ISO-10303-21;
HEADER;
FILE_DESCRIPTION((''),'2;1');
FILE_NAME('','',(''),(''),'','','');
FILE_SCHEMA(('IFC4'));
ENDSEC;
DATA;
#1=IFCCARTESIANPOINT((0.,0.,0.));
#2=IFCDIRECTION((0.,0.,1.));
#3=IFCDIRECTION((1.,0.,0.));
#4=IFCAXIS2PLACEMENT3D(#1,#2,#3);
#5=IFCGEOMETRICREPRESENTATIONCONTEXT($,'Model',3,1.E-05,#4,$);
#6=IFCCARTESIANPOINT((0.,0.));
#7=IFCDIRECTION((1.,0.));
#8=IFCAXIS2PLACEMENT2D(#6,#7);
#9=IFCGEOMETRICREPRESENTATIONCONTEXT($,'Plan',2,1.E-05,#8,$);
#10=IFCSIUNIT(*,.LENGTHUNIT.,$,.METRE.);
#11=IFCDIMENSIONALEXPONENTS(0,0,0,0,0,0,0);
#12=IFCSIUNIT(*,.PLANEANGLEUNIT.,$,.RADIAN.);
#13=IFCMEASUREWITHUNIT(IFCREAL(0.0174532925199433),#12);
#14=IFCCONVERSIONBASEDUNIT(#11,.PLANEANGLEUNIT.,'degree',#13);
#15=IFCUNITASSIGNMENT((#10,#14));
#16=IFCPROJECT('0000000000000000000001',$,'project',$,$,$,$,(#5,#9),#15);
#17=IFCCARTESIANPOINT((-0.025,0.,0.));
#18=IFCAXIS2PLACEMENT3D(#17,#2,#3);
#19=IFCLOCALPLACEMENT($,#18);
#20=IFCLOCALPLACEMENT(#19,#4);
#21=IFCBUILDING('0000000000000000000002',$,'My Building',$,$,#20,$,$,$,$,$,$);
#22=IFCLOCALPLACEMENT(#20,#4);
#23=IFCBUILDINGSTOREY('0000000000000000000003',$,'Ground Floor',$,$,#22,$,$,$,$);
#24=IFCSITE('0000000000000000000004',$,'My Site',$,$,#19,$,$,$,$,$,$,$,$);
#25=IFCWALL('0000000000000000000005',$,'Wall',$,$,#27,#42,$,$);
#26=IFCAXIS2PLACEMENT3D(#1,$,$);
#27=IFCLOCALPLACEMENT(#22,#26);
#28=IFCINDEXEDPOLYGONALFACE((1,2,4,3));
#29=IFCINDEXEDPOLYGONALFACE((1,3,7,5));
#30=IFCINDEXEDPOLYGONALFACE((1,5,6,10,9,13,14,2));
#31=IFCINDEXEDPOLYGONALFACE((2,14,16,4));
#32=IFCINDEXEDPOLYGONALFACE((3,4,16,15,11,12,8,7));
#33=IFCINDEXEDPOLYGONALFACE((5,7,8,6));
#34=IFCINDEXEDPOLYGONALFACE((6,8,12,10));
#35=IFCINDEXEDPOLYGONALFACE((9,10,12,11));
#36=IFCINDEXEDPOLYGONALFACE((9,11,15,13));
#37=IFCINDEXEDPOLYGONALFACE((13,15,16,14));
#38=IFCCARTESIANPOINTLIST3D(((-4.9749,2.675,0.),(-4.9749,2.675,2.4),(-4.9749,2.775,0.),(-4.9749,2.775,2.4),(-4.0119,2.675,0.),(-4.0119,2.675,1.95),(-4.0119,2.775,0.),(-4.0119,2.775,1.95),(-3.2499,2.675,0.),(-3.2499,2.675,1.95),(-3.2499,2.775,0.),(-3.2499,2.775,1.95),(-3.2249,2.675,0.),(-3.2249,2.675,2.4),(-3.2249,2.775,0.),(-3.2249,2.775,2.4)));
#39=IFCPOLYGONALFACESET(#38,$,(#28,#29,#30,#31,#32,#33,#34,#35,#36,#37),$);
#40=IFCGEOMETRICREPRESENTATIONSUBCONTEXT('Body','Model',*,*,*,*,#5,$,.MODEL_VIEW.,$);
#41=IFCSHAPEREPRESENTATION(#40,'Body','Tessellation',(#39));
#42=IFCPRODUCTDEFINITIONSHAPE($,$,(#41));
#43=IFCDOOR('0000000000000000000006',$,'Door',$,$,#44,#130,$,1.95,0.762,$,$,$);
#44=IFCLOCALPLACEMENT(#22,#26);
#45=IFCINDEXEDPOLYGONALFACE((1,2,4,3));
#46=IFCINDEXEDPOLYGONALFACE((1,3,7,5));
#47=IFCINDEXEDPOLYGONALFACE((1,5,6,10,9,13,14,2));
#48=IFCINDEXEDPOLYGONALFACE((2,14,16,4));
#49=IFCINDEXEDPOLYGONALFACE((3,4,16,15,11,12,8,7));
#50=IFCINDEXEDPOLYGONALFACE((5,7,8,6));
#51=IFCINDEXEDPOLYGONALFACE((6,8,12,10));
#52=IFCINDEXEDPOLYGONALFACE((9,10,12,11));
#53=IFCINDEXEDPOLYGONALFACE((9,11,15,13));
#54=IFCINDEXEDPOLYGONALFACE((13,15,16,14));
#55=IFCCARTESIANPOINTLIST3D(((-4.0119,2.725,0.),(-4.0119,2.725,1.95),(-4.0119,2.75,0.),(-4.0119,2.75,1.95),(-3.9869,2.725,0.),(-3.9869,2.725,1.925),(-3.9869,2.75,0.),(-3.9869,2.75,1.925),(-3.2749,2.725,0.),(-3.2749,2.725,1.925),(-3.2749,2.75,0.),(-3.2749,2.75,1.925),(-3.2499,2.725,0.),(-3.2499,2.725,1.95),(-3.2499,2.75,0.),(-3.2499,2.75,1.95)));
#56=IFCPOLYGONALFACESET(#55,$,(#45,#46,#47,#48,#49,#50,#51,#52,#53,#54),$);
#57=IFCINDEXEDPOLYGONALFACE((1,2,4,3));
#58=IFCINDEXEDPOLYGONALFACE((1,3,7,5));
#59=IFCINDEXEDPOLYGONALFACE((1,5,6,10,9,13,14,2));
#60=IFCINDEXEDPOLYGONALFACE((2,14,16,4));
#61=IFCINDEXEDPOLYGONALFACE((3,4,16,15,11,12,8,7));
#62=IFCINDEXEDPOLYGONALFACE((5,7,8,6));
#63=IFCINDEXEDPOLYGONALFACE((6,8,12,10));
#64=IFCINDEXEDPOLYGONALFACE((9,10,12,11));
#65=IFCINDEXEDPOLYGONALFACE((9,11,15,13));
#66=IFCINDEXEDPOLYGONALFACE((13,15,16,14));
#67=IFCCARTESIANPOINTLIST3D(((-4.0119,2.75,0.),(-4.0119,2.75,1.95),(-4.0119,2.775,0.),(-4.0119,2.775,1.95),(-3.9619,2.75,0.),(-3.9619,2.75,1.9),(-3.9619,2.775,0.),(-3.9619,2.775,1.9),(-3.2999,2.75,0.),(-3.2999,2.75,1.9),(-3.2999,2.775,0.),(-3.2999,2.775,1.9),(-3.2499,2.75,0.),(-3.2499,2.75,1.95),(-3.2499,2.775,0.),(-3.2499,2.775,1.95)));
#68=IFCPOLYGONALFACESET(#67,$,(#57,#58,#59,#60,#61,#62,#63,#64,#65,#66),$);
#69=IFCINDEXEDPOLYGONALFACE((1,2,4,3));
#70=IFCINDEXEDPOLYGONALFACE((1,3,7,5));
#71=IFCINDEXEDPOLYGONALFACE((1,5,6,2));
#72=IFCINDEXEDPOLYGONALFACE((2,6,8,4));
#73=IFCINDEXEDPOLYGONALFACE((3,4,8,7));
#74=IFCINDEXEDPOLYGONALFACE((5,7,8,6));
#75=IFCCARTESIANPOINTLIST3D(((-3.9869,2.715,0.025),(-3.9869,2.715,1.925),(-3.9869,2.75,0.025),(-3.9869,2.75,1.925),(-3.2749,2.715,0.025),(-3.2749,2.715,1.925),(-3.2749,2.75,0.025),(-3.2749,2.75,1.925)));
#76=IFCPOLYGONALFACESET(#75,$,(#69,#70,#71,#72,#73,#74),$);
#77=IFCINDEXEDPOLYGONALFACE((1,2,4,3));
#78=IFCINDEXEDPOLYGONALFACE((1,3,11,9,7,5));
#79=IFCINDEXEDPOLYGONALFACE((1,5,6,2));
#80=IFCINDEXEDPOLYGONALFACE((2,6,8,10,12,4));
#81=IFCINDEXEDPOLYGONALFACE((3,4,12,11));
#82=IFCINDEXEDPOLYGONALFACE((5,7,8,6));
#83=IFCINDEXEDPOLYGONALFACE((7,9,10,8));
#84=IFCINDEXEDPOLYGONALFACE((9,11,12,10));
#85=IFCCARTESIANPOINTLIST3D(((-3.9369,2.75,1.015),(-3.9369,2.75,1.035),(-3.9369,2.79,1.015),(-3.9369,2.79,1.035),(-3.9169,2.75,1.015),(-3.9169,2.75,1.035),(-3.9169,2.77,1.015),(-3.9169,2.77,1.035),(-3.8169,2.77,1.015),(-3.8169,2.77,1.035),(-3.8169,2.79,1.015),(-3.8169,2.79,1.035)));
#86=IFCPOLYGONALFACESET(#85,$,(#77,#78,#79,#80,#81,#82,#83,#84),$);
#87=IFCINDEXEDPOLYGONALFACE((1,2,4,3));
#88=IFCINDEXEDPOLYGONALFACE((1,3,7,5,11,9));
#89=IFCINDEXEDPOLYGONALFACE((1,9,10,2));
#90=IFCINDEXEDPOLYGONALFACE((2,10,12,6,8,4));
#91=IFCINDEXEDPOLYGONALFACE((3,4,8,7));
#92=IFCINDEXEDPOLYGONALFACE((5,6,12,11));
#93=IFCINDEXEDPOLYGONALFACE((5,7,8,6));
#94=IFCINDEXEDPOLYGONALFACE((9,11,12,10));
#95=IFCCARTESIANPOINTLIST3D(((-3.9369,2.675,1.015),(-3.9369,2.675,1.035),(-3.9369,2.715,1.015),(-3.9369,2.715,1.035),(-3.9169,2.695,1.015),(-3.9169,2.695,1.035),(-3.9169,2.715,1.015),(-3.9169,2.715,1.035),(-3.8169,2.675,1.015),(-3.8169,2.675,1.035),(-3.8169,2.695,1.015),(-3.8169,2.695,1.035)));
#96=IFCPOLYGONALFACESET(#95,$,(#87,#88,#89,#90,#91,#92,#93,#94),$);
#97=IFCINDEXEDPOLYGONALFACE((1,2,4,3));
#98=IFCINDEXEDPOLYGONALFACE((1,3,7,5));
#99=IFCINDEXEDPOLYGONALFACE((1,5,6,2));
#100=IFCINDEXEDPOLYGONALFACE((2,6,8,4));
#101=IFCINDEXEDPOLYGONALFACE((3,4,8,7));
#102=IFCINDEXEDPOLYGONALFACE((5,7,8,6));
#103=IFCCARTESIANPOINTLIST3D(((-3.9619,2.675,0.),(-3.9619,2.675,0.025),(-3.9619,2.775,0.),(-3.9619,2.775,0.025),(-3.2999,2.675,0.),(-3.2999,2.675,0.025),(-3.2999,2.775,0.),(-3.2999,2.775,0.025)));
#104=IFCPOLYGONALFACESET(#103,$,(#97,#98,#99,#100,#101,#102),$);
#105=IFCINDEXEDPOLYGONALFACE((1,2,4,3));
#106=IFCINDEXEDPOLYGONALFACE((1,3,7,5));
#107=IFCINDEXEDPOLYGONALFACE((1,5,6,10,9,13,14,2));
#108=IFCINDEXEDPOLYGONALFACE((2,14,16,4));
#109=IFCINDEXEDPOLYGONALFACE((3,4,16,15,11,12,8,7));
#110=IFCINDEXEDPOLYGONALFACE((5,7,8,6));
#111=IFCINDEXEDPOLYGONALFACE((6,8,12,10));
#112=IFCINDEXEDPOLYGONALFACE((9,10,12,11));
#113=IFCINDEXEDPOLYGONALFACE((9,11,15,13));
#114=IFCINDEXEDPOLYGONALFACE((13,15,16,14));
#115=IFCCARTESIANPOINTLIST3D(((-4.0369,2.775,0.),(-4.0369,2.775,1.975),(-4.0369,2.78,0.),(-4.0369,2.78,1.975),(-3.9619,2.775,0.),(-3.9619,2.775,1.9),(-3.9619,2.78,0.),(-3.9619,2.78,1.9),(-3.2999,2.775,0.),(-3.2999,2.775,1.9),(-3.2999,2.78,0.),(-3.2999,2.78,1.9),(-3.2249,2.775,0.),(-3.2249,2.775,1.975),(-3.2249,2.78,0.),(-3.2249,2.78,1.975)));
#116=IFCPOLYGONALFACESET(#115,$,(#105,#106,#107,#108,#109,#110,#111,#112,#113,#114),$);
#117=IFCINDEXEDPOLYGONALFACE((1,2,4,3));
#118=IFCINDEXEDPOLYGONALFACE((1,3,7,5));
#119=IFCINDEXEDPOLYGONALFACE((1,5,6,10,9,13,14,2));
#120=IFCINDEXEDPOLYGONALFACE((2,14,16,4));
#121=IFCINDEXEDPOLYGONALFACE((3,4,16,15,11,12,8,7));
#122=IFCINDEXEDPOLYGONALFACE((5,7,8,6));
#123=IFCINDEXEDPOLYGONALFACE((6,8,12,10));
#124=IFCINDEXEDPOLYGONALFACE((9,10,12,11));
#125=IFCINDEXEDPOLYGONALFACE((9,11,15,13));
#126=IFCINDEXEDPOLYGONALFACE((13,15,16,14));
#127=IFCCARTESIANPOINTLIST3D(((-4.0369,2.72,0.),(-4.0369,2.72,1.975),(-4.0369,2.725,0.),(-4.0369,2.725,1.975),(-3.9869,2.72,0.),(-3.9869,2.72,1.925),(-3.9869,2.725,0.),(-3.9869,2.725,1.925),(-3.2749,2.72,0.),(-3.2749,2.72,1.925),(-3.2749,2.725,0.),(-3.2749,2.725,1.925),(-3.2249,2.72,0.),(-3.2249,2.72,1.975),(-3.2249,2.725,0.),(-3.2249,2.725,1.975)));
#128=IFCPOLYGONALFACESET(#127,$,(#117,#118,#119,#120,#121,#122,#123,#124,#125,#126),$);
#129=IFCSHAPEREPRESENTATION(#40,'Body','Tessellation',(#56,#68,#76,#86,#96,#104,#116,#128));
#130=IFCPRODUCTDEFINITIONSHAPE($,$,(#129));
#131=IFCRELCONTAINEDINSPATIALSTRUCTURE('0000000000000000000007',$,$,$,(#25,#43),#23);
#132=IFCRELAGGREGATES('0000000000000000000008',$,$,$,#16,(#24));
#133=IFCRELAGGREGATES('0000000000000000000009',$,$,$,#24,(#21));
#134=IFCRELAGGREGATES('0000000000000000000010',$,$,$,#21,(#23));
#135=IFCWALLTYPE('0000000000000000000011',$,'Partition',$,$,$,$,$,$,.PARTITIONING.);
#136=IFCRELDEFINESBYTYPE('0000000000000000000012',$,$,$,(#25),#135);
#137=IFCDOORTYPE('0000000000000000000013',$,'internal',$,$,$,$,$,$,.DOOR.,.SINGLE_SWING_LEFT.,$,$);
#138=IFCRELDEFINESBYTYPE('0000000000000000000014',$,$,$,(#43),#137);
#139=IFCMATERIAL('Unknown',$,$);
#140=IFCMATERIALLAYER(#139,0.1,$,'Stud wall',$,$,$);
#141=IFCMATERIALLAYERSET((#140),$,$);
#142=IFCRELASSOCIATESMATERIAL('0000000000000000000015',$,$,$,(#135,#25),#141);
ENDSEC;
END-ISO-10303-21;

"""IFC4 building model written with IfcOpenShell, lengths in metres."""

from ifc_helpers import new_model, entity, si_unit, converted_unit, frame, origin_with_axes, origin_2d_with_axis, place, context, subcontext, project, spatial, line, indexed_curve, outline, extrude, shape, source, transform, mapped, material, layer, layer_set, layer_usage, type_object, type_shapes, element, fill, save


model = new_model("IFC4")

# Units and contexts
model_context = context("Model", 3, precision=1e-05, world=origin_with_axes())
plan_context = context("Plan", 2, precision=1e-05, world=origin_2d_with_axis())
body_context_1 = subcontext(model_context, "Body", "Model", "MODEL_VIEW")
body_context_2 = subcontext(plan_context, "Body", "Plan", "PLAN_VIEW")
ifc_project = project(units=[si_unit("LENGTHUNIT", "METRE"), converted_unit("PLANEANGLEUNIT", "degree", entity("IfcReal", 0.0174532925199433), si_unit("PLANEANGLEUNIT", "RADIAN"), dimensions=[0, 0, 0, 0, 0, 0, 0])], contexts=[model_context, plan_context])

# Site, building, storey
site_placement = place(None, frame((-0.025, 0.0, 0.0), z_axis=(0.0, 0.0, 1.0), x_axis=(1.0, 0.0, 0.0)))
site = spatial("IfcSite", under=ifc_project, at=site_placement, Name="My Site")
building_placement = place(site_placement, origin_with_axes())
building = spatial("IfcBuilding", under=site, at=building_placement, Name="My Building")
storey_placement = place(building_placement, frame((0.0, 0.0, 0.0), z_axis=(0.0, 0.0, 1.0), x_axis=(1.0, 0.0, 0.0)))
storey = spatial("IfcBuildingStorey", under=building, at=storey_placement, Name="Ground Floor")

# Shared definitions
ifc_material = material(Name="Unknown")
shared_shape_1 = source(origin_with_axes(), body_context_1, "Body", "SweptSolid", [
    extrude(outline(indexed_curve([(0.0, 0.0), (0.762, 0.0), (0.762, 1.95), (0.0, 1.95)], segments=[line(1, 2, 3, 4, 1)])), frame((0.0, -0.1, 0.0), z_axis=(0.0, -1.0, 0.0), x_axis=(1.0, 0.0, 0.0)), (0.0, 0.0, -1.0), 0.3),
])
door_type = type_object("IfcDoorType", Name="internal", OperationType="SINGLE_SWING_LEFT", PredefinedType="DOOR")
shared_shape_2 = source(origin_with_axes(), body_context_1, "Body", "SweptSolid", [
    extrude(outline(indexed_curve([(0.0, 0.0), (0.0, 1.95), (0.762, 1.95), (0.762, 0.0), (0.737, 0.0), (0.737, 1.925), (0.025, 1.925), (0.025, 0.0)], segments=[line(1, 2, 3, 4, 5, 6, 7, 8, 1)])), frame((0.0, 0.025, 0.0), z_axis=(0.0, -1.0, 0.0), x_axis=(1.0, 0.0, 0.0)), (0.0, 0.0, -1.0), 0.025),
    extrude(outline(indexed_curve([(0.0, 0.0), (0.0, 1.95), (0.762, 1.95), (0.762, 0.0), (0.712, 0.0), (0.712, 1.9), (0.05, 1.9), (0.05, 0.0)], segments=[line(1, 2, 3, 4, 5, 6, 7, 8, 1)])), frame((0.0, 0.0, 0.0), z_axis=(0.0, -1.0, 0.0), x_axis=(1.0, 0.0, 0.0)), (0.0, 0.0, -1.0), 0.025),
    extrude(outline(indexed_curve([(0.0, 0.0), (0.712, 0.0), (0.712, 0.035), (0.0, 0.035)], segments=[line(1, 2, 3, 4, 1)])), frame((0.025, 0.025, 0.025), z_axis=(0.0, 0.0, 1.0), x_axis=(1.0, 0.0, 0.0)), (0.0, 0.0, 1.0), 1.9),
    extrude(outline(indexed_curve([(0.0, 0.0), (0.0, -0.04), (-0.12, -0.04), (-0.12, -0.02), (-0.02, -0.02), (-0.02, 0.0)], segments=[line(1, 2, 3, 4, 5, 6, 1)])), frame((0.687, 0.025, 1.015), z_axis=(0.0, 0.0, 1.0), x_axis=(1.0, 0.0, 0.0)), (0.0, 0.0, 1.0), 0.02),
    extrude(outline(indexed_curve([(0.0, 0.0), (0.0, 0.04), (-0.12, 0.04), (-0.12, 0.02), (-0.02, 0.02), (-0.02, 0.0)], segments=[line(1, 2, 3, 4, 5, 6, 1)])), frame((0.687, 0.06, 1.015), z_axis=(0.0, 0.0, 1.0), x_axis=(1.0, 0.0, 0.0)), (0.0, 0.0, 1.0), 0.02),
    extrude(outline(indexed_curve([(0.0, 0.0), (0.662, 0.0), (0.662, 0.1), (0.0, 0.1)], segments=[line(1, 2, 3, 4, 1)])), frame((0.05, 0.0, 0.0), z_axis=(0.0, 0.0, 1.0), x_axis=(1.0, 0.0, 0.0)), (0.0, 0.0, 1.0), 0.025),
    extrude(outline(indexed_curve([(0.0, 0.0), (0.0, 1.975), (0.812, 1.975), (0.812, 0.0), (0.737, 0.0), (0.737, 1.9), (0.075, 1.9), (0.075, 0.0)], segments=[line(1, 2, 3, 4, 5, 6, 7, 8, 1)])), frame((-0.025, -0.005, 0.0), z_axis=(0.0, -1.0, 0.0), x_axis=(1.0, 0.0, 0.0)), (0.0, 0.0, -1.0), 0.005),
    extrude(outline(indexed_curve([(0.0, 0.0), (0.0, 1.975), (0.812, 1.975), (0.812, 0.0), (0.762, 0.0), (0.762, 1.925), (0.05, 1.925), (0.05, 0.0)], segments=[line(1, 2, 3, 4, 5, 6, 7, 8, 1)])), frame((-0.025, 0.05, 0.0), z_axis=(0.0, -1.0, 0.0), x_axis=(1.0, 0.0, 0.0)), (0.0, 0.0, -1.0), 0.005),
])
shared_shape_3 = source(origin_with_axes(), body_context_2, "Body", "Curve2D", [
    entity("IfcIndexedPolyCurve", entity("IfcCartesianPointList2D", [[0.0, 0.0], [0.0, 0.05], [0.025, 0.05], [0.025, 0.025], [0.05, 0.025], [0.05, 0.0]]), [entity("IfcLineIndex", [1, 2, 3, 4, 5, 6, 1])]),
    entity("IfcIndexedPolyCurve", entity("IfcCartesianPointList2D", [[0.762, 0.0], [0.762, 0.05], [0.737, 0.05], [0.737, 0.025], [0.712, 0.025], [0.712, 0.0]]), [entity("IfcLineIndex", [1, 2, 3, 4, 5, 6, 1])]),
    entity("IfcTrimmedCurve", entity("IfcEllipse", entity("IfcAxis2Placement2D", entity("IfcCartesianPoint", [0.06, 0.05]), entity("IfcDirection", [1.0, 0.0])), 0.677, 0.712), [entity("IfcCartesianPoint", [0.737, 0.05])], [entity("IfcCartesianPoint", [0.06, 0.762])], True, "CARTESIAN"),
    entity("IfcIndexedPolyCurve", entity("IfcCartesianPointList2D", [[0.025, 0.05], [0.06, 0.05], [0.06, 0.762], [0.025, 0.762]]), [entity("IfcLineIndex", [1, 2, 3, 4, 1])]),
])
type_shapes(door_type, [shared_shape_2, shared_shape_3])

# Wall, opening, door
ifc_layer_1 = layer(ifc_material, 0.1, Name="Stud wall")
ifc_layer_set_1 = layer_set([ifc_layer_1])
wall_type_1 = type_object("IfcWallType", Name="Partition", PredefinedType="PARTITIONING", material=ifc_layer_set_1)
ifc_layer_usage_1 = layer_usage(ifc_layer_set_1, "AXIS2", "POSITIVE", 0.0)
wall_1_placement = place(storey_placement, frame((-3.2249, 2.775, 0.0), z_axis=(0.0, 0.0, 1.0), x_axis=(-1.0, 0.0, 0.0)))
wall_1 = element("IfcWall", 1, at=wall_1_placement, inside=storey, type_object=wall_type_1, material=ifc_layer_usage_1, Name="Wall", context=body_context_1, shape_type="SweptSolid", body=[
    extrude(outline(indexed_curve([(0.0, 0.0), (0.0, 0.1), (1.75, 0.1), (1.75, 0.0), (0.0, 0.0)], self_intersect=False)), origin_with_axes(), (0.0, 0.0, 1.0), 2.4),
])
opening_1_placement = place(wall_1_placement, frame((0.025, 0.0, 0.0), z_axis=(0.0, 0.0, 1.0), x_axis=(1.0, 0.0, 0.0)))
opening_1 = element("IfcOpeningElement", 2, at=opening_1_placement, cuts=wall_1, PredefinedType="OPENING", context=body_context_1, shape_type="MappedRepresentation", body=[
    mapped(shared_shape_1, transform((0.0, 0.0, 0.0), x_axis=(1.0, 0.0, 0.0), y_axis=(0.0, 1.0, 0.0), z_axis=(0.0, 0.0, 1.0), scale=1.0)),
])
door_1_placement = place(opening_1_placement, frame((0.0, 0.0, 0.0), z_axis=(0.0, 0.0, 1.0), x_axis=(1.0, 0.0, 0.0)))
door_1 = element("IfcDoor", 3, at=door_1_placement, inside=storey, type_object=door_type, Name="Door", OverallHeight=1.95, OverallWidth=0.762, shapes=[
    shape(body_context_1, "Body", "MappedRepresentation", [mapped(shared_shape_2, transform((0.0, 0.0, 0.0), x_axis=(1.0, 0.0, 0.0), y_axis=(0.0, 1.0, 0.0), z_axis=(0.0, 0.0, 1.0), scale=1.0))]),
    shape(body_context_2, "Body", "MappedRepresentation", [mapped(shared_shape_3, transform((0.0, 0.0, 0.0), x_axis=(1.0, 0.0, 0.0), y_axis=(0.0, 1.0, 0.0), z_axis=(0.0, 0.0, 1.0), scale=1.0))]),
])
fill(opening_1, door_1)

save(model, "model.ifc")
